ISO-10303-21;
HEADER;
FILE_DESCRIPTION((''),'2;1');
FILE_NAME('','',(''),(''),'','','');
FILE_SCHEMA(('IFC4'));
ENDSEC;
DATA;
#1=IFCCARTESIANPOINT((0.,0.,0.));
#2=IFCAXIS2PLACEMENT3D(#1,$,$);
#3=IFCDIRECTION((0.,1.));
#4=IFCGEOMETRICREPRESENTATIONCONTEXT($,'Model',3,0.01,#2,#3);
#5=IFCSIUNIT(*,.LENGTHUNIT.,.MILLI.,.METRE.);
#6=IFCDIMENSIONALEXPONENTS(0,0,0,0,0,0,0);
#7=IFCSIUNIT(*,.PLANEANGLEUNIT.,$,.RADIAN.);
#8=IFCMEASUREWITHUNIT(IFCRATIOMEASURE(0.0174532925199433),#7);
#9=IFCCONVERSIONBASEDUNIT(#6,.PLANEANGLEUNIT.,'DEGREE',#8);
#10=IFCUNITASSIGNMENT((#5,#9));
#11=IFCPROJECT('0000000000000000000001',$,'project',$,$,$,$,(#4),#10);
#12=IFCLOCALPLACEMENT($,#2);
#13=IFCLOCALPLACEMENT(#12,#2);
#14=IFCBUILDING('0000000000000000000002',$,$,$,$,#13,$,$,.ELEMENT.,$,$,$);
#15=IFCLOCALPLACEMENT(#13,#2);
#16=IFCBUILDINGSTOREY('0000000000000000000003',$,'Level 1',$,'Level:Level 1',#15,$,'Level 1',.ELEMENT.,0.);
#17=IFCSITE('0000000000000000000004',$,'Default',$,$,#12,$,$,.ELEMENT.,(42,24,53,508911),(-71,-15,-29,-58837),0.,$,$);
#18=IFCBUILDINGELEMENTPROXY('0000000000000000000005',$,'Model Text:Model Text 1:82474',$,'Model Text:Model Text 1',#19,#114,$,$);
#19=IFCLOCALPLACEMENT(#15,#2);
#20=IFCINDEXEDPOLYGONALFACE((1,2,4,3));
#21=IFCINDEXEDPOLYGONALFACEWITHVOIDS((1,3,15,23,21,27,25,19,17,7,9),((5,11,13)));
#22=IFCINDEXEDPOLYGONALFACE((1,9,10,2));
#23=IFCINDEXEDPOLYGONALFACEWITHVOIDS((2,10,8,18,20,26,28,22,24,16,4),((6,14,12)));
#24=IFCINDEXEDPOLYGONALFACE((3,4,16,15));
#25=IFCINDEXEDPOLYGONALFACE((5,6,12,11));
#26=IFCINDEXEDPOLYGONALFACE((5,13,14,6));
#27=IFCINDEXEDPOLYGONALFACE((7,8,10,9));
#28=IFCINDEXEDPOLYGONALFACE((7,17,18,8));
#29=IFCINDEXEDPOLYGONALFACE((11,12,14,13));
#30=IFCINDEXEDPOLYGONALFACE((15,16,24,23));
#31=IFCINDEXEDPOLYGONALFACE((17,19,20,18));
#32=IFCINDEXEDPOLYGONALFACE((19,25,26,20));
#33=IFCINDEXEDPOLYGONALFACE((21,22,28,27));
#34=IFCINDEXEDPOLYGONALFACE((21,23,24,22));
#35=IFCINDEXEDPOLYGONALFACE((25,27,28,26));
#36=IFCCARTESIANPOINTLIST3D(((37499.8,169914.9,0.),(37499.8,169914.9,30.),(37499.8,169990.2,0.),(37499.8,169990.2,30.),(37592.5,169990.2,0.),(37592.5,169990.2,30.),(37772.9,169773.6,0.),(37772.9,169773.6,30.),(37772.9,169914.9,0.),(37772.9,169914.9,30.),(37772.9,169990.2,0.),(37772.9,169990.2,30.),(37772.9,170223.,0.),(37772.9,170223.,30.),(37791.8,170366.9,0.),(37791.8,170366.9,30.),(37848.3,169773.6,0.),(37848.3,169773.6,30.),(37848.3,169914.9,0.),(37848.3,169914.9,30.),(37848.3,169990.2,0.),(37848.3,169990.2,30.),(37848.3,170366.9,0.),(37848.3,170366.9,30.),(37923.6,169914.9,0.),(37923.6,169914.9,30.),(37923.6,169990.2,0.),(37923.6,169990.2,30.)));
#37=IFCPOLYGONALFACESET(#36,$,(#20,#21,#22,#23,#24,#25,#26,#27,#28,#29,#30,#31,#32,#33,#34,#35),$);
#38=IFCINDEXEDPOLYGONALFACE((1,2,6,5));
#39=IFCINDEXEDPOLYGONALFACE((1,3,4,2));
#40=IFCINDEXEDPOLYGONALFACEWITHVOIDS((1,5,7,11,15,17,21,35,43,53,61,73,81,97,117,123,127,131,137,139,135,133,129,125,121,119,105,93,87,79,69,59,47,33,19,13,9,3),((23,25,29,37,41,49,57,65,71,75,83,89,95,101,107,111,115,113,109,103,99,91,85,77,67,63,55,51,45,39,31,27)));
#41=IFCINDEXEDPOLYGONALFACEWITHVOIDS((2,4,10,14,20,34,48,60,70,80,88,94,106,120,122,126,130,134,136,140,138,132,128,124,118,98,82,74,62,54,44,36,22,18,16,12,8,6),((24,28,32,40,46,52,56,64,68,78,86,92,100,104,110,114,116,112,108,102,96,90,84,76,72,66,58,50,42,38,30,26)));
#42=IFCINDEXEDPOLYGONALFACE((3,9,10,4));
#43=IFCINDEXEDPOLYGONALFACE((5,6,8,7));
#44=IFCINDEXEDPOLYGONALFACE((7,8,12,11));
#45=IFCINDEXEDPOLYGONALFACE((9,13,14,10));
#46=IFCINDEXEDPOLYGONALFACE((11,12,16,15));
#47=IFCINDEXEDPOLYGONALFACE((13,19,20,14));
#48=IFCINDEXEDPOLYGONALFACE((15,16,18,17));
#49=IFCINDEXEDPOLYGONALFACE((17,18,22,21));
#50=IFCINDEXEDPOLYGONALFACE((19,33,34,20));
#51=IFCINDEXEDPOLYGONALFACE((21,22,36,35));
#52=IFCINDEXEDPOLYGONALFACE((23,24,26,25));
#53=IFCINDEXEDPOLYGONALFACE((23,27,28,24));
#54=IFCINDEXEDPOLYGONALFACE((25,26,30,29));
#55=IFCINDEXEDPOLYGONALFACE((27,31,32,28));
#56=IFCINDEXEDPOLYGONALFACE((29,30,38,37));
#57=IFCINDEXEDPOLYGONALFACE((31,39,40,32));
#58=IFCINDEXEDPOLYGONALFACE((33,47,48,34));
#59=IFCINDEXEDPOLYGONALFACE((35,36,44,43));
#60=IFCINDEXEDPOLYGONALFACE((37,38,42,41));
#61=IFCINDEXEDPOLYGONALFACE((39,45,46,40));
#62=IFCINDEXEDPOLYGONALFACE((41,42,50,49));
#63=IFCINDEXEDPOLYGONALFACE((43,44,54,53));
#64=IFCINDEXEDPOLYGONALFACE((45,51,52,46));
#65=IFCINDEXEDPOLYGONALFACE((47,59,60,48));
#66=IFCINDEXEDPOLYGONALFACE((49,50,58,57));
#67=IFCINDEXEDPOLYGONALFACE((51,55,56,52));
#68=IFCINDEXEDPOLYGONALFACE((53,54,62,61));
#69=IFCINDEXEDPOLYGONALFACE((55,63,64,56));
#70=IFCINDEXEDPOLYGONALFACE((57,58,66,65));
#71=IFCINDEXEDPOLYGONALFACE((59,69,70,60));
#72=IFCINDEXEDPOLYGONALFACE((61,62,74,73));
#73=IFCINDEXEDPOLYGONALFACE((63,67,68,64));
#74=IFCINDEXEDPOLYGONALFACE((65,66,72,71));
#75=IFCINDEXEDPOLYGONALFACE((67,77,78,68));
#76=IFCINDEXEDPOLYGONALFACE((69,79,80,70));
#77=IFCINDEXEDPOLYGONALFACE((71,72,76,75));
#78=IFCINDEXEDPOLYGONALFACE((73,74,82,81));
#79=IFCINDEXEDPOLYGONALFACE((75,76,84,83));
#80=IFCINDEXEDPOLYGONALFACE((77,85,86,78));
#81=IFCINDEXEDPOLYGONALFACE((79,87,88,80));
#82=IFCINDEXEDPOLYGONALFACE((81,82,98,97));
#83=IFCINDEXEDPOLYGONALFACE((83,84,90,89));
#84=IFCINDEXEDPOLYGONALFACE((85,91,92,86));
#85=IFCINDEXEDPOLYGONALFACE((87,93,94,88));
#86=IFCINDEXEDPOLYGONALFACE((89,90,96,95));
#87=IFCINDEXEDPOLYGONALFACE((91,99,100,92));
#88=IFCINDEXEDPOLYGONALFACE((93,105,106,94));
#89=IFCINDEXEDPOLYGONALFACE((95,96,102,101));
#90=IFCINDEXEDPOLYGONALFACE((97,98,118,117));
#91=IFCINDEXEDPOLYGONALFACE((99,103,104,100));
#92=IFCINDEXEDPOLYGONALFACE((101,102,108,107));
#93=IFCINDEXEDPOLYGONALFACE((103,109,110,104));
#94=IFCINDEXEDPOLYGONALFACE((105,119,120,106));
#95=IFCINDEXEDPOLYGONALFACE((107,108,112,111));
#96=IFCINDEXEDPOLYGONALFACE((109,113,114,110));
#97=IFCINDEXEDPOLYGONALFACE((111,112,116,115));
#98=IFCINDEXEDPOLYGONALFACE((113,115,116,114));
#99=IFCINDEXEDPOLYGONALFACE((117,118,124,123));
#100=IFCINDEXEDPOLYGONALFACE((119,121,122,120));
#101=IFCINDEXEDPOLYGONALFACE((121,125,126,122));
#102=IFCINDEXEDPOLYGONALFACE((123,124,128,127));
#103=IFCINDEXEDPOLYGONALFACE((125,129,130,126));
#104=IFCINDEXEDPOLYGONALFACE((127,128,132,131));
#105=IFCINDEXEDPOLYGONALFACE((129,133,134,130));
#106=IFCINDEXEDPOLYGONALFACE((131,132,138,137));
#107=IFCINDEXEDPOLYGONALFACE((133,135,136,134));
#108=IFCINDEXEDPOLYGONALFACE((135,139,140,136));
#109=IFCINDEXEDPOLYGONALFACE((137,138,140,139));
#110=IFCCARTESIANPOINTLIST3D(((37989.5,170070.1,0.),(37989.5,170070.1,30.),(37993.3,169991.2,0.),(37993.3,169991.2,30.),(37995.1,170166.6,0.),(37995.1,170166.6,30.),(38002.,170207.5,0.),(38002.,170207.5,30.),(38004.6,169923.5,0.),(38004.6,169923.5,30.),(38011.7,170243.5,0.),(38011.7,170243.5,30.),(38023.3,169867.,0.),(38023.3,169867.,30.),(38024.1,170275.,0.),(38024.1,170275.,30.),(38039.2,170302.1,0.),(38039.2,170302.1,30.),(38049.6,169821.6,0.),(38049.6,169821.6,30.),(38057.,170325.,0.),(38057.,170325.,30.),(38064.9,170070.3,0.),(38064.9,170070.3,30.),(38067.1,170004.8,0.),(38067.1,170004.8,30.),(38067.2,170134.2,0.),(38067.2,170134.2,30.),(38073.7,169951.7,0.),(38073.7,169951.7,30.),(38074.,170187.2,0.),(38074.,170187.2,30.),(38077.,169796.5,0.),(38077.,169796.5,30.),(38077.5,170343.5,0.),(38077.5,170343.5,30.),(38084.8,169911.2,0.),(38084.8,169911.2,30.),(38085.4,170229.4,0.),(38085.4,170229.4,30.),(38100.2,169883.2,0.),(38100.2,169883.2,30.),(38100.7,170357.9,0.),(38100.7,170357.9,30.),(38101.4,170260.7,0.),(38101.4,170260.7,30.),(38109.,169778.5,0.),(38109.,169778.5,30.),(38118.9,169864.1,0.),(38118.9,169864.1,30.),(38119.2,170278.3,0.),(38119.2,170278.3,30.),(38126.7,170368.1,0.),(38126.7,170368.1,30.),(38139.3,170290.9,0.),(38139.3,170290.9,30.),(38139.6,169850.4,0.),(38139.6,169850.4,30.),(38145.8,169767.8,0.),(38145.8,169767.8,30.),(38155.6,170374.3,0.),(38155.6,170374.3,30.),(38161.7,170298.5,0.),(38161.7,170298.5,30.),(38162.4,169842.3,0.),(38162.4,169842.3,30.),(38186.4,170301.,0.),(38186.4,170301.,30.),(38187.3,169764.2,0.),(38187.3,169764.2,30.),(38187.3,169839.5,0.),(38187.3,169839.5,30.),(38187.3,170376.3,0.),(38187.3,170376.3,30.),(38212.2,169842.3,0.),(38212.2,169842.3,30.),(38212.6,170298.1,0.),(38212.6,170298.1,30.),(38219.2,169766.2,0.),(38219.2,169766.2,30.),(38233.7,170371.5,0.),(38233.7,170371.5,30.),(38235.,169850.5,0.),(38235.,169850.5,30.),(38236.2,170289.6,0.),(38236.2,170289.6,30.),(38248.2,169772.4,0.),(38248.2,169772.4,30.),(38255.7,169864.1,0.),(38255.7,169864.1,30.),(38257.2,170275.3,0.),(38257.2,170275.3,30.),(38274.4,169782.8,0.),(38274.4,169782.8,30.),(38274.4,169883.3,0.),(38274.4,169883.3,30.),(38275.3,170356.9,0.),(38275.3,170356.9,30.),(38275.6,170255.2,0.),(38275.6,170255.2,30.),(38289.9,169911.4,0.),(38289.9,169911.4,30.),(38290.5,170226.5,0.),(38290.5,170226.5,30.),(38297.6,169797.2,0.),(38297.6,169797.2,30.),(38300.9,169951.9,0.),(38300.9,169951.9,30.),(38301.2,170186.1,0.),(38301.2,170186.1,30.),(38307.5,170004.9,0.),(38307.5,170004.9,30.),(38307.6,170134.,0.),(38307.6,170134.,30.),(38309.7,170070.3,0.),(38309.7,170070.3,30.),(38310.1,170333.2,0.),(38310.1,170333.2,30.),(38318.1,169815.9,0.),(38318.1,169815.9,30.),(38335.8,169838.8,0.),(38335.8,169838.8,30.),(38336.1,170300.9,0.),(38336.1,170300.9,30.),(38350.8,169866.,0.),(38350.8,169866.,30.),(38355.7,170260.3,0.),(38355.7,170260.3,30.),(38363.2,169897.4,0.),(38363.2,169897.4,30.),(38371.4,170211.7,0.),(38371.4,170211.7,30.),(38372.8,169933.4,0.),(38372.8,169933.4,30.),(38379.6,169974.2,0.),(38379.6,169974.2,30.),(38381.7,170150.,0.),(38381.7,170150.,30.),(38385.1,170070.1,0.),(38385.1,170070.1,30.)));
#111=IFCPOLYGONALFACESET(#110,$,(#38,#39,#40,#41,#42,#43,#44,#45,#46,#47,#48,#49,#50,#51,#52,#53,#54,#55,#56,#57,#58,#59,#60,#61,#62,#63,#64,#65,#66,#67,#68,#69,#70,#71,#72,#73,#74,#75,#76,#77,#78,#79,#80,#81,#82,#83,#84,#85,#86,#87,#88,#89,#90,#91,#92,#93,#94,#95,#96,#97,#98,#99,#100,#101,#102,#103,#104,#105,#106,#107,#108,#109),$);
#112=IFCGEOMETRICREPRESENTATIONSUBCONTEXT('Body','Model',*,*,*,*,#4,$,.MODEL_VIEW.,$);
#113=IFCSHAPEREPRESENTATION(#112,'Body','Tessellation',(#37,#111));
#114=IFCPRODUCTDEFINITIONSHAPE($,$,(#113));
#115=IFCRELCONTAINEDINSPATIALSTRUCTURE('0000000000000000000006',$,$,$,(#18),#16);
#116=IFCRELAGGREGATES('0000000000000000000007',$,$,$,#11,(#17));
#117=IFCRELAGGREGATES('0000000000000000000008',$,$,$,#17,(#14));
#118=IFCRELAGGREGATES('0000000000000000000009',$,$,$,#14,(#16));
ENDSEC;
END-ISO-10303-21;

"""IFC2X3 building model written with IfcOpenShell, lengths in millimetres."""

from ifc_helpers import new_model, entity, si_unit, converted_unit, direction, frame, origin, place, context, subcontext, project, spatial, polyline, outline, extrude, element, save


model = new_model("IFC2X3")

# Units and contexts
model_context = context("Model", 3, precision=0.01, world=origin(), true_north=direction((0.0, 1.0)))
body_context = subcontext(model_context, "Body", "Model", "MODEL_VIEW")
ifc_project = project(units=[si_unit("LENGTHUNIT", "METRE", prefix="MILLI"), converted_unit("PLANEANGLEUNIT", "DEGREE", entity("IfcRatioMeasure", 0.0174532925199433), si_unit("PLANEANGLEUNIT", "RADIAN"), dimensions=[0, 0, 0, 0, 0, 0, 0])], contexts=[model_context])

# Site, building, storey
site_placement = place(None, origin())
site = spatial("IfcSite", under=ifc_project, at=site_placement, Name="Default", CompositionType="ELEMENT", RefLatitude=(42, 24, 53, 508911), RefLongitude=(-71, -15, -29, -58837), RefElevation=0.0)
building_placement = place(site_placement, origin())
building = spatial("IfcBuilding", under=site, at=building_placement, CompositionType="ELEMENT")
storey_placement = place(building_placement, origin())
storey = spatial("IfcBuildingStorey", under=building, at=storey_placement, Name="Level 1", ObjectType="Level:Level 1", LongName="Level 1", CompositionType="ELEMENT", Elevation=0.0)

# Building element proxy
proxy_1_placement = place(storey_placement, origin())
element("IfcBuildingElementProxy", 1, at=proxy_1_placement, inside=storey, Name="Model Text:Model Text 1:82474", ObjectType="Model Text:Model Text 1", context=body_context, shape_type="SweptSolid", body=[
    extrude(outline(polyline([(-6.8, -218.3), (68.5, -218.3), (68.5, -77.1), (143.8, -77.1), (143.8, -1.7), (68.5, -1.7), (68.5, 375.0), (12.0, 375.0), (-280.0, -1.7), (-280.0, -77.1), (-6.8, -77.1), (-6.8, -218.3)]), holes=[polyline([(-6.8, -1.7), (-187.3, -1.7), (-6.8, 231.1), (-6.8, -1.7)])]), frame((37779.8, 169991.9, 0.0)), (0.0, 0.0, 1.0), 30.0),
    extrude(outline(polyline([(-10.6, -198.7), (68.3, -198.7), (136.5, -190.7), (193.9, -174.7), (240.5, -150.6), (266.9, -124.4), (286.3, -93.2), (298.8, -57.0), (304.3, -15.7), (303.8, 16.2), (299.0, 45.5), (289.9, 72.1), (276.6, 96.0), (258.9, 117.3), (236.9, 136.2), (210.4, 152.5), (179.6, 166.3), (144.1, 177.6), (103.7, 186.3), (8.2, 196.4), (-71.8, 196.7), (-134.0, 189.4), (-183.3, 176.1), (-224.7, 158.4), (-258.2, 133.9), (-283.5, 100.3), (-300.1, 59.5), (-307.1, 13.4), (-306.6, -18.4), (-301.8, -47.5), (-292.8, -74.0), (-279.6, -97.9), (-262.0, -119.2), (-240.0, -138.1), (-213.6, -154.5), (-182.8, -168.4), (-147.3, -179.8), (-106.7, -188.6), (-10.6, -198.7)]), holes=[polyline([(-7.2, -123.5), (-71.0, -118.2), (-123.6, -108.8), (-165.2, -95.4), (-195.7, -78.0), (-212.4, -59.4), (-224.1, -38.7), (-230.6, -15.9), (-231.9, 8.9), (-227.8, 35.0), (-218.1, 58.1), (-202.8, 78.4), (-182.0, 95.8), (-152.6, 109.4), (-111.7, 118.1), (-59.4, 122.0), (4.4, 121.1), (69.6, 115.8), (122.2, 106.7), (162.2, 93.7), (189.5, 77.0), (207.7, 57.4), (220.4, 36.0), (227.5, 12.8), (229.1, -12.1), (225.2, -36.8), (215.9, -59.2), (201.3, -79.3), (181.4, -97.1), (152.6, -111.2), (111.6, -120.3), (58.3, -124.4), (-7.2, -123.5)])]), frame((38188.6, 170068.9, 0.0), z_axis=(0.0, 0.0, 1.0), x_axis=(0.047515, -0.998871, 0.0)), (0.0, 0.0, 1.0), 30.0),
])

save(model, "model.ifc")
